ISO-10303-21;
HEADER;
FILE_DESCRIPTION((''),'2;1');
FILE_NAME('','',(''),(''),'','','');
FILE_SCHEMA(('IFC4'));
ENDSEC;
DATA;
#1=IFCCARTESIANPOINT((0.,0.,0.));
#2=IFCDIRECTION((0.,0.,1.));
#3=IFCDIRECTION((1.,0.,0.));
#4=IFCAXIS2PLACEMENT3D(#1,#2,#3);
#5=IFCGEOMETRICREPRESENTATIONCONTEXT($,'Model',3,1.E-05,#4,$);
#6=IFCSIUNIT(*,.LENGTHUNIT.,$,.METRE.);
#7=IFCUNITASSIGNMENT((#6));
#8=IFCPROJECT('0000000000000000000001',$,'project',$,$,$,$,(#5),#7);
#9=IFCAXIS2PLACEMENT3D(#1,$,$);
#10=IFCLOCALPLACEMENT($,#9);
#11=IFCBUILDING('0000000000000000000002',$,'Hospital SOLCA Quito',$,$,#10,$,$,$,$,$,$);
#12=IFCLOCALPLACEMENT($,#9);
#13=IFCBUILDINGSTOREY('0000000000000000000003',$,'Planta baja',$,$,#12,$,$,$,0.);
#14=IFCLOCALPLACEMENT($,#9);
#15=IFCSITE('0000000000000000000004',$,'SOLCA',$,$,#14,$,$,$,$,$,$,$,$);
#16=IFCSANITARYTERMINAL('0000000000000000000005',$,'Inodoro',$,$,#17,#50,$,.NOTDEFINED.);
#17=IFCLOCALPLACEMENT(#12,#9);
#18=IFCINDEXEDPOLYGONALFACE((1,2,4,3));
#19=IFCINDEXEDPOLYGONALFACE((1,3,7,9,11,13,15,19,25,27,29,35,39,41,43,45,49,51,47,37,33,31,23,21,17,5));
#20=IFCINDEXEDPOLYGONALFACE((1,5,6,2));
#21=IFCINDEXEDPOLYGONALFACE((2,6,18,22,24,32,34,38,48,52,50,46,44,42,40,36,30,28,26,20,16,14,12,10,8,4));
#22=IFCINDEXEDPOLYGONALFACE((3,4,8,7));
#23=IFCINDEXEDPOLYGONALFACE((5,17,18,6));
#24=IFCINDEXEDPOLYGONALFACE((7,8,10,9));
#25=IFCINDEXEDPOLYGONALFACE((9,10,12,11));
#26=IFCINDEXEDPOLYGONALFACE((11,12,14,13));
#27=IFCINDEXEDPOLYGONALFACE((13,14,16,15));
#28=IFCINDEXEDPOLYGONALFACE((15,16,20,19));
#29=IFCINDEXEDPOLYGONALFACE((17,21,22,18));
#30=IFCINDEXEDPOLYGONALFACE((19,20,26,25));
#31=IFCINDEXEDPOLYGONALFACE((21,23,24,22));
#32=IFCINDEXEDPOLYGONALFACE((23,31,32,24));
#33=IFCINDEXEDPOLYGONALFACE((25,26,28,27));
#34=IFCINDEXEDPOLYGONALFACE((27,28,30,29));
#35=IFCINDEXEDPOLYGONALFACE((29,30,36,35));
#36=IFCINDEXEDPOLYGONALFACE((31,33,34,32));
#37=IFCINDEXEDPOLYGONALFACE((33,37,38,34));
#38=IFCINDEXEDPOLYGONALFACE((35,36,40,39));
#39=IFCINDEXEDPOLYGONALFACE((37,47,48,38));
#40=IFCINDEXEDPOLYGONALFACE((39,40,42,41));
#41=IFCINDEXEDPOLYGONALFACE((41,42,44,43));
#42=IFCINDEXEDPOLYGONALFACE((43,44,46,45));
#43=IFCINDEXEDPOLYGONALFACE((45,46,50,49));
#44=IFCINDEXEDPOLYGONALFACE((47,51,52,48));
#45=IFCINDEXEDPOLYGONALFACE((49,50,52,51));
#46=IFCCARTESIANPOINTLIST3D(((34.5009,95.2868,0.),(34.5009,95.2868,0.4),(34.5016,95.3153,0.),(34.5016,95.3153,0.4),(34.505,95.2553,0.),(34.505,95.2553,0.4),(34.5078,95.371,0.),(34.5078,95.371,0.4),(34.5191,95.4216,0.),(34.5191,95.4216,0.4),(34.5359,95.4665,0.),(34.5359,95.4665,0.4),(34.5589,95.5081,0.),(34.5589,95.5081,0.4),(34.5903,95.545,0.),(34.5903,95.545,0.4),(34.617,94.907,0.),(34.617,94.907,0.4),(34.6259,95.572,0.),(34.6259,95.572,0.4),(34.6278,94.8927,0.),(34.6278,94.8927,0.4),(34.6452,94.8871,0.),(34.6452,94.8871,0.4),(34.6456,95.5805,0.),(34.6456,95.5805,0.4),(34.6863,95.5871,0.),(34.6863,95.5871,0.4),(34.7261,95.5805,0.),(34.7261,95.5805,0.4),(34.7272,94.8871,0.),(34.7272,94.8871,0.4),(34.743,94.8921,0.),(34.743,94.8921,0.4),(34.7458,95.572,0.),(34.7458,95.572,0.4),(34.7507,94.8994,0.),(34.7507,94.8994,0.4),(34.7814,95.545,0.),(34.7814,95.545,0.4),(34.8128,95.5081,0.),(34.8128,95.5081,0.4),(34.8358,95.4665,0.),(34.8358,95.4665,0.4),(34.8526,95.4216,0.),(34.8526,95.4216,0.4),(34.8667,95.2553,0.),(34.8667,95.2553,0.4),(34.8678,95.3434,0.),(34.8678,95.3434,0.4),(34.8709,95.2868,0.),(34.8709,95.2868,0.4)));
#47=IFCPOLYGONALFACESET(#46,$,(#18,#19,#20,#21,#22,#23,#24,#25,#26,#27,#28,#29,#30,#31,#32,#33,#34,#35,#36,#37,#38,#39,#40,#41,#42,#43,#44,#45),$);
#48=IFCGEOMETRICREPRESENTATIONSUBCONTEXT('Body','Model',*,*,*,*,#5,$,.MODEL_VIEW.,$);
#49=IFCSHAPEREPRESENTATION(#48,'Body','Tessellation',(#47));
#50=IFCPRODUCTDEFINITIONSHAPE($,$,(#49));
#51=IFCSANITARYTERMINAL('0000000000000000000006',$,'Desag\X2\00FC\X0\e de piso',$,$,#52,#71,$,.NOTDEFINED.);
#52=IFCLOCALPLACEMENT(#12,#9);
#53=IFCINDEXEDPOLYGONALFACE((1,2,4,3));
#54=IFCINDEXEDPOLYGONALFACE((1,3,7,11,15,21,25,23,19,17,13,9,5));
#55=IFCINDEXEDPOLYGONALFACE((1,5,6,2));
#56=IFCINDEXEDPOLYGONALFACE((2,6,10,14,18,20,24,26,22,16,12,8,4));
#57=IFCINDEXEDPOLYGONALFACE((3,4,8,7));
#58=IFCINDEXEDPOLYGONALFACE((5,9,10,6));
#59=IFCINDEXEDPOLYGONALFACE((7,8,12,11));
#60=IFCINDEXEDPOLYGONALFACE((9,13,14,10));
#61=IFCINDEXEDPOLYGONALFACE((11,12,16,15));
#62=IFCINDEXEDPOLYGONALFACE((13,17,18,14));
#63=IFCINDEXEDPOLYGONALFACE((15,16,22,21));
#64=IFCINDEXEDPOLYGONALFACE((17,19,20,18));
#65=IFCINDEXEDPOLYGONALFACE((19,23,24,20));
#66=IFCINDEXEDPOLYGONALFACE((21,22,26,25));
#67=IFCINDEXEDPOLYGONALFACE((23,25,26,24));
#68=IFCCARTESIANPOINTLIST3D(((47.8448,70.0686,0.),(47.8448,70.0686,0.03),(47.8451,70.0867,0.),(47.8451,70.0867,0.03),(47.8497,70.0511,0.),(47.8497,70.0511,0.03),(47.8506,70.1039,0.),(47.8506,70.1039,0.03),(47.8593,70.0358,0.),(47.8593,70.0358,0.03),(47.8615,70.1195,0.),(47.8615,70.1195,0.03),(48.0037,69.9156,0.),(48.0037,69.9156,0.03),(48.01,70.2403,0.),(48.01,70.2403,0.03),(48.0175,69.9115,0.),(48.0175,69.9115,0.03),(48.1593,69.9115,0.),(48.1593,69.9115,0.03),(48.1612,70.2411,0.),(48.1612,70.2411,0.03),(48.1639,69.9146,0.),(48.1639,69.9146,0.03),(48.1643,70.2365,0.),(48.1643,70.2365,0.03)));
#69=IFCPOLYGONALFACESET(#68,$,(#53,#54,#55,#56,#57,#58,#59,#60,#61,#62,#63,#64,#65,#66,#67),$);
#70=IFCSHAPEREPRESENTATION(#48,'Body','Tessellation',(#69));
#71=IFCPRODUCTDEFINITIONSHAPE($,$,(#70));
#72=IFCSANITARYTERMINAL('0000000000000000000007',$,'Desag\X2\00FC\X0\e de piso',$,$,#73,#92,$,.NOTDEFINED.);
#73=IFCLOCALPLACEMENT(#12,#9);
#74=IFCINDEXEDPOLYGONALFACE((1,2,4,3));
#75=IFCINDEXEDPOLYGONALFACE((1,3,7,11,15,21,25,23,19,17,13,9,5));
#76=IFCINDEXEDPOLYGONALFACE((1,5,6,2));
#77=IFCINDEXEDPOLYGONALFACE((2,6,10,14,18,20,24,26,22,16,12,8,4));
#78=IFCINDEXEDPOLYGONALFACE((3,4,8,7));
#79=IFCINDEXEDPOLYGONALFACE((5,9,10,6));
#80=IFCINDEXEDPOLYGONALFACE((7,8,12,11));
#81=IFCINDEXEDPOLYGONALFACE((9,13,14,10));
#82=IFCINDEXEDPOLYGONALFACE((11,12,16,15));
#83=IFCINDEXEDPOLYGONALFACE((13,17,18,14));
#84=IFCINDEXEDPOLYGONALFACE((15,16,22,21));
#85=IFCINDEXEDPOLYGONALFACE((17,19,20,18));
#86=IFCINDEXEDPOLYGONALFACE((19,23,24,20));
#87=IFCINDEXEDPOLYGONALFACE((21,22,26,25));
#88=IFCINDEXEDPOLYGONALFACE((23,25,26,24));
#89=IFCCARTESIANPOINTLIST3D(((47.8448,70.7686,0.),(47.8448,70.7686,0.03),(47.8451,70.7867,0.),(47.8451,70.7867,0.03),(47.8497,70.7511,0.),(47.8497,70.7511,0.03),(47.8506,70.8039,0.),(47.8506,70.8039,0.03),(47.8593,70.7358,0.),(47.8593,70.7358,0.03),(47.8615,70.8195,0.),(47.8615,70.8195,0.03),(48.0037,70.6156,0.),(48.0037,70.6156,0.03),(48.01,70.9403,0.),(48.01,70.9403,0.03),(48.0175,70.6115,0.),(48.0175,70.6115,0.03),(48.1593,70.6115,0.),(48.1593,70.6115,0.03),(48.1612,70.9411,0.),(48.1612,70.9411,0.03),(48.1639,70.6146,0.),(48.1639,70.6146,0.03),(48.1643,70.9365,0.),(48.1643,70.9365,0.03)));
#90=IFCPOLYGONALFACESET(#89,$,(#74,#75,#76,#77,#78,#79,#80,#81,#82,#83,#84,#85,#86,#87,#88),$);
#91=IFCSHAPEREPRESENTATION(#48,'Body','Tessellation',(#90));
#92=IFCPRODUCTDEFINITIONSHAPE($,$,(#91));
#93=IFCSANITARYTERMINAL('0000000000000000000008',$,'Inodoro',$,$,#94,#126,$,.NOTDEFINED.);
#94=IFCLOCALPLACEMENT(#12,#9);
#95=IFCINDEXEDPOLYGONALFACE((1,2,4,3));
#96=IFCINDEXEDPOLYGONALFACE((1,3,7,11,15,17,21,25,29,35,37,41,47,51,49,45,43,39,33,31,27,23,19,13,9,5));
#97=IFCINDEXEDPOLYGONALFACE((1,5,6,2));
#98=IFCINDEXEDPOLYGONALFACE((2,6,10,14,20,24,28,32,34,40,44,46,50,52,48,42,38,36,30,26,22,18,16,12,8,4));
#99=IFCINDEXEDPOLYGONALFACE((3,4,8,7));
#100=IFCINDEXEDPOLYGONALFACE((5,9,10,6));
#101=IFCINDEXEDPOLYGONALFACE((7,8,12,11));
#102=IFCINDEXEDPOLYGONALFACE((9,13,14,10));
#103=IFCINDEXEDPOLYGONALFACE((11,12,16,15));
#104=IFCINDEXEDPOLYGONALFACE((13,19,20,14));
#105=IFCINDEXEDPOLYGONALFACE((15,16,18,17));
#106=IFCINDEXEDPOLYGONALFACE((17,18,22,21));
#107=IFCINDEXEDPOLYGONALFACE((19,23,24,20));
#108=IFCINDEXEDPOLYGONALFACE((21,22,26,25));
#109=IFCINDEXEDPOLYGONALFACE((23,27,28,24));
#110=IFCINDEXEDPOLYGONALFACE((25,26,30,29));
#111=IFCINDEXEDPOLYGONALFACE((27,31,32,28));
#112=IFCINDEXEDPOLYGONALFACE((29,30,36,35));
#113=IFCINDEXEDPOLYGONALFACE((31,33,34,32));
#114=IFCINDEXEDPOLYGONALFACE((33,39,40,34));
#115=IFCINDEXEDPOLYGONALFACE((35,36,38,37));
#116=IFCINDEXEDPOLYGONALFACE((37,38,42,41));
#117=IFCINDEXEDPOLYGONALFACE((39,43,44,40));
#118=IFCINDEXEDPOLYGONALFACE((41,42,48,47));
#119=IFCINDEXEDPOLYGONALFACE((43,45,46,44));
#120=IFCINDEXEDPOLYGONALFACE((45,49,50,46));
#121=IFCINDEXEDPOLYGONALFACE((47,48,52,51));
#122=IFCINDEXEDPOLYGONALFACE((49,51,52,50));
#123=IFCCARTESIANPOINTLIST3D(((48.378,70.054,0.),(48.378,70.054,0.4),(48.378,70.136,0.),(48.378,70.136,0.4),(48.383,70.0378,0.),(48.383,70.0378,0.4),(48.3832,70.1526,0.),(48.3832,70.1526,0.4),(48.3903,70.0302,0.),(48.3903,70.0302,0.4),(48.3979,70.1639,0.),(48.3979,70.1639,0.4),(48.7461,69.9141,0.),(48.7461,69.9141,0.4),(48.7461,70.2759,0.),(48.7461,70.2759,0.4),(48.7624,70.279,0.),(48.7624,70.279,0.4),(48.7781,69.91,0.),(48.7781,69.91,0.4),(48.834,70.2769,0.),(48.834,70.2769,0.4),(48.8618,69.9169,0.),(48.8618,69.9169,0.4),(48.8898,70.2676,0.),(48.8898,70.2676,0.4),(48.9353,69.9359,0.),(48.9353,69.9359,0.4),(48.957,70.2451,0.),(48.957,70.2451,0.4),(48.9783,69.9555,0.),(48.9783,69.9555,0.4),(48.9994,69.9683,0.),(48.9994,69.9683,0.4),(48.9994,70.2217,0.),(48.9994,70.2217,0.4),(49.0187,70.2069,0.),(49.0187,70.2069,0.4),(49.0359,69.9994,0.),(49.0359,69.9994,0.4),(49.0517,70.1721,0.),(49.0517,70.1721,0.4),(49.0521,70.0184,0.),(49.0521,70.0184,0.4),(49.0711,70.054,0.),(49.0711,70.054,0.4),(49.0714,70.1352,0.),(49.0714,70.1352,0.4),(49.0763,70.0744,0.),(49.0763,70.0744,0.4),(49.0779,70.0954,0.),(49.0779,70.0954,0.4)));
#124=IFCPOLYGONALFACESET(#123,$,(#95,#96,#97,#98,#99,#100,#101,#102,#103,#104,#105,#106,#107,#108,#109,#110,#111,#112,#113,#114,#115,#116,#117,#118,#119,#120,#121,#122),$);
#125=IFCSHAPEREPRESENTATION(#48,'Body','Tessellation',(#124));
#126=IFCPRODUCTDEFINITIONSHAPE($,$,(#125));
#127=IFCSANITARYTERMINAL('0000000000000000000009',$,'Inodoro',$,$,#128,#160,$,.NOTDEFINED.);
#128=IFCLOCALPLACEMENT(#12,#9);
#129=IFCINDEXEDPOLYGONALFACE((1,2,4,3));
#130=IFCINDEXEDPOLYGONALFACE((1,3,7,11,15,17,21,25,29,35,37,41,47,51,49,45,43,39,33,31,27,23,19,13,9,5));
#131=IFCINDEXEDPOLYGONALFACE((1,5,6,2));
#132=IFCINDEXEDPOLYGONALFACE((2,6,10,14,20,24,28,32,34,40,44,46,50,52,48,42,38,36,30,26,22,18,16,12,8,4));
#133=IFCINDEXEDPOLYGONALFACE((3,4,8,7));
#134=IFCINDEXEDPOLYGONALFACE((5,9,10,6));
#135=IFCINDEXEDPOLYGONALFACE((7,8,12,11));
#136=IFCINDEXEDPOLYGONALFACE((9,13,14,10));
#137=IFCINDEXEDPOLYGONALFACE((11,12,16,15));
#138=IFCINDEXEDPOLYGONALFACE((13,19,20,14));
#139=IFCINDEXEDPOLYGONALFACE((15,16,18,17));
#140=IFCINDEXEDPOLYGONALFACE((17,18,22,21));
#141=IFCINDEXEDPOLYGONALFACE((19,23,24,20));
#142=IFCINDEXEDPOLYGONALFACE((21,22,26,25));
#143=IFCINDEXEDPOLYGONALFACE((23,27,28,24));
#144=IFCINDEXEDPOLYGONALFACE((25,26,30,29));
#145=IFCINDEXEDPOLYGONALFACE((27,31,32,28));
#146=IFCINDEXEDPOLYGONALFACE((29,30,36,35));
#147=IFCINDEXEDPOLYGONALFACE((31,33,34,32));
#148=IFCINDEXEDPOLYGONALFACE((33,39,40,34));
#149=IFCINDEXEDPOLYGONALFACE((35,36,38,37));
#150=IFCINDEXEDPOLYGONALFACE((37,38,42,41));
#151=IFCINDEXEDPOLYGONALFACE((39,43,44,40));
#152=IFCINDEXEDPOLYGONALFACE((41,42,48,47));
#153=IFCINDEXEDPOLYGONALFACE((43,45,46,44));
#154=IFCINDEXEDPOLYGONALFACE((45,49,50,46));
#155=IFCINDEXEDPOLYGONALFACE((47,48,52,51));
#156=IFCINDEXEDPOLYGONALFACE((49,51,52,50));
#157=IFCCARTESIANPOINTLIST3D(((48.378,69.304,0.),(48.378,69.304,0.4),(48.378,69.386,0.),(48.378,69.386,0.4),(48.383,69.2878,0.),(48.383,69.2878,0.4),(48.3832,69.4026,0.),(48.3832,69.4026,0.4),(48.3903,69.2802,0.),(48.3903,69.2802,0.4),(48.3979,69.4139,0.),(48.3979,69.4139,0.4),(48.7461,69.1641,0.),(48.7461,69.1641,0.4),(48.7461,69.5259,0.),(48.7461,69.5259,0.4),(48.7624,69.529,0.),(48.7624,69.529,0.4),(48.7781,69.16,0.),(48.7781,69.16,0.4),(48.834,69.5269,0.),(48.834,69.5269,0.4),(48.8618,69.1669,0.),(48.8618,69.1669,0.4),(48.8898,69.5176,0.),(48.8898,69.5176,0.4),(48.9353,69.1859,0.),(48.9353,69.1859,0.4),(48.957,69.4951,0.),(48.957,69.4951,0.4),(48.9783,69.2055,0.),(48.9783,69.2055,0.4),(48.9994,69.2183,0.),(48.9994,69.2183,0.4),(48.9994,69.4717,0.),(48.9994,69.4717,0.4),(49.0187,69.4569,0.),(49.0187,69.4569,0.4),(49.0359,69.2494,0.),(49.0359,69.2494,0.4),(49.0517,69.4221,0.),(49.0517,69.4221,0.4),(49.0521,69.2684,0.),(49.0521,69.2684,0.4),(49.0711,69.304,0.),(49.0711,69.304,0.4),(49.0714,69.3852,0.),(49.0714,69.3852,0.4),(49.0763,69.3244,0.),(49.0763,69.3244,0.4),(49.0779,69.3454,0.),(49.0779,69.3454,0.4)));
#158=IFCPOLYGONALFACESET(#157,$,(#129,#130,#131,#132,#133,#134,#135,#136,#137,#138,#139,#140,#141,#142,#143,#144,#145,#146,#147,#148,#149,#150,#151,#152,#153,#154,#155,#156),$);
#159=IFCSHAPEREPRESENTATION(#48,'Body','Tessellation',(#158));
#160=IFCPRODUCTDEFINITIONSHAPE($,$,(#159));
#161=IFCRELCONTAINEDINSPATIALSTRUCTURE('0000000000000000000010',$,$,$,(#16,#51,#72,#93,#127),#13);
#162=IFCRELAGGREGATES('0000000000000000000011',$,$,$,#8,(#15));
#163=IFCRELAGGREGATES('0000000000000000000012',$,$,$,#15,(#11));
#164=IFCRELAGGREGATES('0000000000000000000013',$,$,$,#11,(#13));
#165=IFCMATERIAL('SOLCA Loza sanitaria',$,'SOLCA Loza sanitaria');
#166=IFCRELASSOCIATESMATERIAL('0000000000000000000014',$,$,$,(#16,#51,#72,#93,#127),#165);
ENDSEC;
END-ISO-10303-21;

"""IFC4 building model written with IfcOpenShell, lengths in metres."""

from ifc_helpers import new_model, si_unit, origin, origin_with_axes, place, context, subcontext, project, spatial, polyline, outline, extrude, material, element, save


model = new_model("IFC4")

# Units and contexts
model_context = context("Model", 3, precision=1e-05, world=origin_with_axes())
body_context = subcontext(model_context, "Body", "Model", "MODEL_VIEW")
ifc_project = project(units=[si_unit("LENGTHUNIT", "METRE")], contexts=[model_context])

# Site, building, storey
site_placement = place(None, origin())
site = spatial("IfcSite", under=ifc_project, at=site_placement, Name="SOLCA")
building_placement = place(None, origin())
building = spatial("IfcBuilding", under=site, at=building_placement, Name="Hospital SOLCA Quito")
storey_placement = place(None, origin())
storey = spatial("IfcBuildingStorey", under=building, at=storey_placement, Name="Planta baja", Elevation=0.0)

# Sanitary terminals
ifc_material = material(Name="SOLCA Loza sanitaria", Category="SOLCA Loza sanitaria")
sanitary_terminal_1_placement = place(storey_placement, origin_with_axes())
element("IfcSanitaryTerminal", 1, at=sanitary_terminal_1_placement, inside=storey, material=ifc_material, Name="Inodoro", PredefinedType="NOTDEFINED", context=body_context, shape_type="SweptSolid", body=[
    extrude(outline(polyline([(34.6452, 94.8871), (34.6278, 94.8927), (34.617, 94.907), (34.505, 95.2553), (34.5009, 95.2868), (34.5016, 95.3153), (34.5078, 95.371), (34.5191, 95.4216), (34.5359, 95.4665), (34.5589, 95.5081), (34.5903, 95.545), (34.6259, 95.572), (34.6456, 95.5805), (34.6863, 95.5871), (34.7261, 95.5805), (34.7458, 95.572), (34.7814, 95.545), (34.8128, 95.5081), (34.8358, 95.4665), (34.8526, 95.4216), (34.8678, 95.3434), (34.8709, 95.2868), (34.8667, 95.2553), (34.7507, 94.8994), (34.743, 94.8921), (34.7272, 94.8871), (34.6452, 94.8871)])), origin_with_axes(), (0.0, 0.0, 1.0), 0.4),
])
sanitary_terminal_2_placement = place(storey_placement, origin_with_axes())
element("IfcSanitaryTerminal", 2, at=sanitary_terminal_2_placement, inside=storey, material=ifc_material, Name="Desagüe de piso", PredefinedType="NOTDEFINED", context=body_context, shape_type="SweptSolid", body=[
    extrude(outline(polyline([(48.0175, 69.9115), (48.0037, 69.9156), (47.8593, 70.0358), (47.8497, 70.0511), (47.8448, 70.0686), (47.8451, 70.0867), (47.8506, 70.1039), (47.8615, 70.1195), (48.01, 70.2403), (48.1612, 70.2411), (48.1643, 70.2365), (48.1639, 69.9146), (48.1593, 69.9115), (48.0175, 69.9115)])), origin_with_axes(), (0.0, 0.0, 1.0), 0.03),
])
sanitary_terminal_3_placement = place(storey_placement, origin_with_axes())
element("IfcSanitaryTerminal", 3, at=sanitary_terminal_3_placement, inside=storey, material=ifc_material, Name="Desagüe de piso", PredefinedType="NOTDEFINED", context=body_context, shape_type="SweptSolid", body=[
    extrude(outline(polyline([(48.0175, 70.6115), (48.0037, 70.6156), (47.8593, 70.7358), (47.8497, 70.7511), (47.8448, 70.7686), (47.8451, 70.7867), (47.8506, 70.8039), (47.8615, 70.8195), (48.01, 70.9403), (48.1612, 70.9411), (48.1643, 70.9365), (48.1639, 70.6146), (48.1593, 70.6115), (48.0175, 70.6115)])), origin_with_axes(), (0.0, 0.0, 1.0), 0.03),
])
sanitary_terminal_4_placement = place(storey_placement, origin_with_axes())
element("IfcSanitaryTerminal", 4, at=sanitary_terminal_4_placement, inside=storey, material=ifc_material, Name="Inodoro", PredefinedType="NOTDEFINED", context=body_context, shape_type="SweptSolid", body=[
    extrude(outline(polyline([(48.7781, 69.91), (48.7461, 69.9141), (48.3903, 70.0302), (48.383, 70.0378), (48.378, 70.054), (48.378, 70.136), (48.3832, 70.1526), (48.3979, 70.1639), (48.7461, 70.2759), (48.7624, 70.279), (48.834, 70.2769), (48.8898, 70.2676), (48.957, 70.2451), (48.9994, 70.2217), (49.0187, 70.2069), (49.0517, 70.1721), (49.0714, 70.1352), (49.0779, 70.0954), (49.0763, 70.0744), (49.0711, 70.054), (49.0521, 70.0184), (49.0359, 69.9994), (48.9994, 69.9683), (48.9783, 69.9555), (48.9353, 69.9359), (48.8618, 69.9169), (48.7781, 69.91)])), origin_with_axes(), (0.0, 0.0, 1.0), 0.4),
])
sanitary_terminal_5_placement = place(storey_placement, origin_with_axes())
element("IfcSanitaryTerminal", 5, at=sanitary_terminal_5_placement, inside=storey, material=ifc_material, Name="Inodoro", PredefinedType="NOTDEFINED", context=body_context, shape_type="SweptSolid", body=[
    extrude(outline(polyline([(48.7781, 69.16), (48.7461, 69.1641), (48.3903, 69.2802), (48.383, 69.2878), (48.378, 69.304), (48.378, 69.386), (48.3832, 69.4026), (48.3979, 69.4139), (48.7461, 69.5259), (48.7624, 69.529), (48.834, 69.5269), (48.8898, 69.5176), (48.957, 69.4951), (48.9994, 69.4717), (49.0187, 69.4569), (49.0517, 69.4221), (49.0714, 69.3852), (49.0779, 69.3454), (49.0763, 69.3244), (49.0711, 69.304), (49.0521, 69.2684), (49.0359, 69.2494), (48.9994, 69.2183), (48.9783, 69.2055), (48.9353, 69.1859), (48.8618, 69.1669), (48.7781, 69.16)])), origin_with_axes(), (0.0, 0.0, 1.0), 0.4),
])

save(model, "model.ifc")
